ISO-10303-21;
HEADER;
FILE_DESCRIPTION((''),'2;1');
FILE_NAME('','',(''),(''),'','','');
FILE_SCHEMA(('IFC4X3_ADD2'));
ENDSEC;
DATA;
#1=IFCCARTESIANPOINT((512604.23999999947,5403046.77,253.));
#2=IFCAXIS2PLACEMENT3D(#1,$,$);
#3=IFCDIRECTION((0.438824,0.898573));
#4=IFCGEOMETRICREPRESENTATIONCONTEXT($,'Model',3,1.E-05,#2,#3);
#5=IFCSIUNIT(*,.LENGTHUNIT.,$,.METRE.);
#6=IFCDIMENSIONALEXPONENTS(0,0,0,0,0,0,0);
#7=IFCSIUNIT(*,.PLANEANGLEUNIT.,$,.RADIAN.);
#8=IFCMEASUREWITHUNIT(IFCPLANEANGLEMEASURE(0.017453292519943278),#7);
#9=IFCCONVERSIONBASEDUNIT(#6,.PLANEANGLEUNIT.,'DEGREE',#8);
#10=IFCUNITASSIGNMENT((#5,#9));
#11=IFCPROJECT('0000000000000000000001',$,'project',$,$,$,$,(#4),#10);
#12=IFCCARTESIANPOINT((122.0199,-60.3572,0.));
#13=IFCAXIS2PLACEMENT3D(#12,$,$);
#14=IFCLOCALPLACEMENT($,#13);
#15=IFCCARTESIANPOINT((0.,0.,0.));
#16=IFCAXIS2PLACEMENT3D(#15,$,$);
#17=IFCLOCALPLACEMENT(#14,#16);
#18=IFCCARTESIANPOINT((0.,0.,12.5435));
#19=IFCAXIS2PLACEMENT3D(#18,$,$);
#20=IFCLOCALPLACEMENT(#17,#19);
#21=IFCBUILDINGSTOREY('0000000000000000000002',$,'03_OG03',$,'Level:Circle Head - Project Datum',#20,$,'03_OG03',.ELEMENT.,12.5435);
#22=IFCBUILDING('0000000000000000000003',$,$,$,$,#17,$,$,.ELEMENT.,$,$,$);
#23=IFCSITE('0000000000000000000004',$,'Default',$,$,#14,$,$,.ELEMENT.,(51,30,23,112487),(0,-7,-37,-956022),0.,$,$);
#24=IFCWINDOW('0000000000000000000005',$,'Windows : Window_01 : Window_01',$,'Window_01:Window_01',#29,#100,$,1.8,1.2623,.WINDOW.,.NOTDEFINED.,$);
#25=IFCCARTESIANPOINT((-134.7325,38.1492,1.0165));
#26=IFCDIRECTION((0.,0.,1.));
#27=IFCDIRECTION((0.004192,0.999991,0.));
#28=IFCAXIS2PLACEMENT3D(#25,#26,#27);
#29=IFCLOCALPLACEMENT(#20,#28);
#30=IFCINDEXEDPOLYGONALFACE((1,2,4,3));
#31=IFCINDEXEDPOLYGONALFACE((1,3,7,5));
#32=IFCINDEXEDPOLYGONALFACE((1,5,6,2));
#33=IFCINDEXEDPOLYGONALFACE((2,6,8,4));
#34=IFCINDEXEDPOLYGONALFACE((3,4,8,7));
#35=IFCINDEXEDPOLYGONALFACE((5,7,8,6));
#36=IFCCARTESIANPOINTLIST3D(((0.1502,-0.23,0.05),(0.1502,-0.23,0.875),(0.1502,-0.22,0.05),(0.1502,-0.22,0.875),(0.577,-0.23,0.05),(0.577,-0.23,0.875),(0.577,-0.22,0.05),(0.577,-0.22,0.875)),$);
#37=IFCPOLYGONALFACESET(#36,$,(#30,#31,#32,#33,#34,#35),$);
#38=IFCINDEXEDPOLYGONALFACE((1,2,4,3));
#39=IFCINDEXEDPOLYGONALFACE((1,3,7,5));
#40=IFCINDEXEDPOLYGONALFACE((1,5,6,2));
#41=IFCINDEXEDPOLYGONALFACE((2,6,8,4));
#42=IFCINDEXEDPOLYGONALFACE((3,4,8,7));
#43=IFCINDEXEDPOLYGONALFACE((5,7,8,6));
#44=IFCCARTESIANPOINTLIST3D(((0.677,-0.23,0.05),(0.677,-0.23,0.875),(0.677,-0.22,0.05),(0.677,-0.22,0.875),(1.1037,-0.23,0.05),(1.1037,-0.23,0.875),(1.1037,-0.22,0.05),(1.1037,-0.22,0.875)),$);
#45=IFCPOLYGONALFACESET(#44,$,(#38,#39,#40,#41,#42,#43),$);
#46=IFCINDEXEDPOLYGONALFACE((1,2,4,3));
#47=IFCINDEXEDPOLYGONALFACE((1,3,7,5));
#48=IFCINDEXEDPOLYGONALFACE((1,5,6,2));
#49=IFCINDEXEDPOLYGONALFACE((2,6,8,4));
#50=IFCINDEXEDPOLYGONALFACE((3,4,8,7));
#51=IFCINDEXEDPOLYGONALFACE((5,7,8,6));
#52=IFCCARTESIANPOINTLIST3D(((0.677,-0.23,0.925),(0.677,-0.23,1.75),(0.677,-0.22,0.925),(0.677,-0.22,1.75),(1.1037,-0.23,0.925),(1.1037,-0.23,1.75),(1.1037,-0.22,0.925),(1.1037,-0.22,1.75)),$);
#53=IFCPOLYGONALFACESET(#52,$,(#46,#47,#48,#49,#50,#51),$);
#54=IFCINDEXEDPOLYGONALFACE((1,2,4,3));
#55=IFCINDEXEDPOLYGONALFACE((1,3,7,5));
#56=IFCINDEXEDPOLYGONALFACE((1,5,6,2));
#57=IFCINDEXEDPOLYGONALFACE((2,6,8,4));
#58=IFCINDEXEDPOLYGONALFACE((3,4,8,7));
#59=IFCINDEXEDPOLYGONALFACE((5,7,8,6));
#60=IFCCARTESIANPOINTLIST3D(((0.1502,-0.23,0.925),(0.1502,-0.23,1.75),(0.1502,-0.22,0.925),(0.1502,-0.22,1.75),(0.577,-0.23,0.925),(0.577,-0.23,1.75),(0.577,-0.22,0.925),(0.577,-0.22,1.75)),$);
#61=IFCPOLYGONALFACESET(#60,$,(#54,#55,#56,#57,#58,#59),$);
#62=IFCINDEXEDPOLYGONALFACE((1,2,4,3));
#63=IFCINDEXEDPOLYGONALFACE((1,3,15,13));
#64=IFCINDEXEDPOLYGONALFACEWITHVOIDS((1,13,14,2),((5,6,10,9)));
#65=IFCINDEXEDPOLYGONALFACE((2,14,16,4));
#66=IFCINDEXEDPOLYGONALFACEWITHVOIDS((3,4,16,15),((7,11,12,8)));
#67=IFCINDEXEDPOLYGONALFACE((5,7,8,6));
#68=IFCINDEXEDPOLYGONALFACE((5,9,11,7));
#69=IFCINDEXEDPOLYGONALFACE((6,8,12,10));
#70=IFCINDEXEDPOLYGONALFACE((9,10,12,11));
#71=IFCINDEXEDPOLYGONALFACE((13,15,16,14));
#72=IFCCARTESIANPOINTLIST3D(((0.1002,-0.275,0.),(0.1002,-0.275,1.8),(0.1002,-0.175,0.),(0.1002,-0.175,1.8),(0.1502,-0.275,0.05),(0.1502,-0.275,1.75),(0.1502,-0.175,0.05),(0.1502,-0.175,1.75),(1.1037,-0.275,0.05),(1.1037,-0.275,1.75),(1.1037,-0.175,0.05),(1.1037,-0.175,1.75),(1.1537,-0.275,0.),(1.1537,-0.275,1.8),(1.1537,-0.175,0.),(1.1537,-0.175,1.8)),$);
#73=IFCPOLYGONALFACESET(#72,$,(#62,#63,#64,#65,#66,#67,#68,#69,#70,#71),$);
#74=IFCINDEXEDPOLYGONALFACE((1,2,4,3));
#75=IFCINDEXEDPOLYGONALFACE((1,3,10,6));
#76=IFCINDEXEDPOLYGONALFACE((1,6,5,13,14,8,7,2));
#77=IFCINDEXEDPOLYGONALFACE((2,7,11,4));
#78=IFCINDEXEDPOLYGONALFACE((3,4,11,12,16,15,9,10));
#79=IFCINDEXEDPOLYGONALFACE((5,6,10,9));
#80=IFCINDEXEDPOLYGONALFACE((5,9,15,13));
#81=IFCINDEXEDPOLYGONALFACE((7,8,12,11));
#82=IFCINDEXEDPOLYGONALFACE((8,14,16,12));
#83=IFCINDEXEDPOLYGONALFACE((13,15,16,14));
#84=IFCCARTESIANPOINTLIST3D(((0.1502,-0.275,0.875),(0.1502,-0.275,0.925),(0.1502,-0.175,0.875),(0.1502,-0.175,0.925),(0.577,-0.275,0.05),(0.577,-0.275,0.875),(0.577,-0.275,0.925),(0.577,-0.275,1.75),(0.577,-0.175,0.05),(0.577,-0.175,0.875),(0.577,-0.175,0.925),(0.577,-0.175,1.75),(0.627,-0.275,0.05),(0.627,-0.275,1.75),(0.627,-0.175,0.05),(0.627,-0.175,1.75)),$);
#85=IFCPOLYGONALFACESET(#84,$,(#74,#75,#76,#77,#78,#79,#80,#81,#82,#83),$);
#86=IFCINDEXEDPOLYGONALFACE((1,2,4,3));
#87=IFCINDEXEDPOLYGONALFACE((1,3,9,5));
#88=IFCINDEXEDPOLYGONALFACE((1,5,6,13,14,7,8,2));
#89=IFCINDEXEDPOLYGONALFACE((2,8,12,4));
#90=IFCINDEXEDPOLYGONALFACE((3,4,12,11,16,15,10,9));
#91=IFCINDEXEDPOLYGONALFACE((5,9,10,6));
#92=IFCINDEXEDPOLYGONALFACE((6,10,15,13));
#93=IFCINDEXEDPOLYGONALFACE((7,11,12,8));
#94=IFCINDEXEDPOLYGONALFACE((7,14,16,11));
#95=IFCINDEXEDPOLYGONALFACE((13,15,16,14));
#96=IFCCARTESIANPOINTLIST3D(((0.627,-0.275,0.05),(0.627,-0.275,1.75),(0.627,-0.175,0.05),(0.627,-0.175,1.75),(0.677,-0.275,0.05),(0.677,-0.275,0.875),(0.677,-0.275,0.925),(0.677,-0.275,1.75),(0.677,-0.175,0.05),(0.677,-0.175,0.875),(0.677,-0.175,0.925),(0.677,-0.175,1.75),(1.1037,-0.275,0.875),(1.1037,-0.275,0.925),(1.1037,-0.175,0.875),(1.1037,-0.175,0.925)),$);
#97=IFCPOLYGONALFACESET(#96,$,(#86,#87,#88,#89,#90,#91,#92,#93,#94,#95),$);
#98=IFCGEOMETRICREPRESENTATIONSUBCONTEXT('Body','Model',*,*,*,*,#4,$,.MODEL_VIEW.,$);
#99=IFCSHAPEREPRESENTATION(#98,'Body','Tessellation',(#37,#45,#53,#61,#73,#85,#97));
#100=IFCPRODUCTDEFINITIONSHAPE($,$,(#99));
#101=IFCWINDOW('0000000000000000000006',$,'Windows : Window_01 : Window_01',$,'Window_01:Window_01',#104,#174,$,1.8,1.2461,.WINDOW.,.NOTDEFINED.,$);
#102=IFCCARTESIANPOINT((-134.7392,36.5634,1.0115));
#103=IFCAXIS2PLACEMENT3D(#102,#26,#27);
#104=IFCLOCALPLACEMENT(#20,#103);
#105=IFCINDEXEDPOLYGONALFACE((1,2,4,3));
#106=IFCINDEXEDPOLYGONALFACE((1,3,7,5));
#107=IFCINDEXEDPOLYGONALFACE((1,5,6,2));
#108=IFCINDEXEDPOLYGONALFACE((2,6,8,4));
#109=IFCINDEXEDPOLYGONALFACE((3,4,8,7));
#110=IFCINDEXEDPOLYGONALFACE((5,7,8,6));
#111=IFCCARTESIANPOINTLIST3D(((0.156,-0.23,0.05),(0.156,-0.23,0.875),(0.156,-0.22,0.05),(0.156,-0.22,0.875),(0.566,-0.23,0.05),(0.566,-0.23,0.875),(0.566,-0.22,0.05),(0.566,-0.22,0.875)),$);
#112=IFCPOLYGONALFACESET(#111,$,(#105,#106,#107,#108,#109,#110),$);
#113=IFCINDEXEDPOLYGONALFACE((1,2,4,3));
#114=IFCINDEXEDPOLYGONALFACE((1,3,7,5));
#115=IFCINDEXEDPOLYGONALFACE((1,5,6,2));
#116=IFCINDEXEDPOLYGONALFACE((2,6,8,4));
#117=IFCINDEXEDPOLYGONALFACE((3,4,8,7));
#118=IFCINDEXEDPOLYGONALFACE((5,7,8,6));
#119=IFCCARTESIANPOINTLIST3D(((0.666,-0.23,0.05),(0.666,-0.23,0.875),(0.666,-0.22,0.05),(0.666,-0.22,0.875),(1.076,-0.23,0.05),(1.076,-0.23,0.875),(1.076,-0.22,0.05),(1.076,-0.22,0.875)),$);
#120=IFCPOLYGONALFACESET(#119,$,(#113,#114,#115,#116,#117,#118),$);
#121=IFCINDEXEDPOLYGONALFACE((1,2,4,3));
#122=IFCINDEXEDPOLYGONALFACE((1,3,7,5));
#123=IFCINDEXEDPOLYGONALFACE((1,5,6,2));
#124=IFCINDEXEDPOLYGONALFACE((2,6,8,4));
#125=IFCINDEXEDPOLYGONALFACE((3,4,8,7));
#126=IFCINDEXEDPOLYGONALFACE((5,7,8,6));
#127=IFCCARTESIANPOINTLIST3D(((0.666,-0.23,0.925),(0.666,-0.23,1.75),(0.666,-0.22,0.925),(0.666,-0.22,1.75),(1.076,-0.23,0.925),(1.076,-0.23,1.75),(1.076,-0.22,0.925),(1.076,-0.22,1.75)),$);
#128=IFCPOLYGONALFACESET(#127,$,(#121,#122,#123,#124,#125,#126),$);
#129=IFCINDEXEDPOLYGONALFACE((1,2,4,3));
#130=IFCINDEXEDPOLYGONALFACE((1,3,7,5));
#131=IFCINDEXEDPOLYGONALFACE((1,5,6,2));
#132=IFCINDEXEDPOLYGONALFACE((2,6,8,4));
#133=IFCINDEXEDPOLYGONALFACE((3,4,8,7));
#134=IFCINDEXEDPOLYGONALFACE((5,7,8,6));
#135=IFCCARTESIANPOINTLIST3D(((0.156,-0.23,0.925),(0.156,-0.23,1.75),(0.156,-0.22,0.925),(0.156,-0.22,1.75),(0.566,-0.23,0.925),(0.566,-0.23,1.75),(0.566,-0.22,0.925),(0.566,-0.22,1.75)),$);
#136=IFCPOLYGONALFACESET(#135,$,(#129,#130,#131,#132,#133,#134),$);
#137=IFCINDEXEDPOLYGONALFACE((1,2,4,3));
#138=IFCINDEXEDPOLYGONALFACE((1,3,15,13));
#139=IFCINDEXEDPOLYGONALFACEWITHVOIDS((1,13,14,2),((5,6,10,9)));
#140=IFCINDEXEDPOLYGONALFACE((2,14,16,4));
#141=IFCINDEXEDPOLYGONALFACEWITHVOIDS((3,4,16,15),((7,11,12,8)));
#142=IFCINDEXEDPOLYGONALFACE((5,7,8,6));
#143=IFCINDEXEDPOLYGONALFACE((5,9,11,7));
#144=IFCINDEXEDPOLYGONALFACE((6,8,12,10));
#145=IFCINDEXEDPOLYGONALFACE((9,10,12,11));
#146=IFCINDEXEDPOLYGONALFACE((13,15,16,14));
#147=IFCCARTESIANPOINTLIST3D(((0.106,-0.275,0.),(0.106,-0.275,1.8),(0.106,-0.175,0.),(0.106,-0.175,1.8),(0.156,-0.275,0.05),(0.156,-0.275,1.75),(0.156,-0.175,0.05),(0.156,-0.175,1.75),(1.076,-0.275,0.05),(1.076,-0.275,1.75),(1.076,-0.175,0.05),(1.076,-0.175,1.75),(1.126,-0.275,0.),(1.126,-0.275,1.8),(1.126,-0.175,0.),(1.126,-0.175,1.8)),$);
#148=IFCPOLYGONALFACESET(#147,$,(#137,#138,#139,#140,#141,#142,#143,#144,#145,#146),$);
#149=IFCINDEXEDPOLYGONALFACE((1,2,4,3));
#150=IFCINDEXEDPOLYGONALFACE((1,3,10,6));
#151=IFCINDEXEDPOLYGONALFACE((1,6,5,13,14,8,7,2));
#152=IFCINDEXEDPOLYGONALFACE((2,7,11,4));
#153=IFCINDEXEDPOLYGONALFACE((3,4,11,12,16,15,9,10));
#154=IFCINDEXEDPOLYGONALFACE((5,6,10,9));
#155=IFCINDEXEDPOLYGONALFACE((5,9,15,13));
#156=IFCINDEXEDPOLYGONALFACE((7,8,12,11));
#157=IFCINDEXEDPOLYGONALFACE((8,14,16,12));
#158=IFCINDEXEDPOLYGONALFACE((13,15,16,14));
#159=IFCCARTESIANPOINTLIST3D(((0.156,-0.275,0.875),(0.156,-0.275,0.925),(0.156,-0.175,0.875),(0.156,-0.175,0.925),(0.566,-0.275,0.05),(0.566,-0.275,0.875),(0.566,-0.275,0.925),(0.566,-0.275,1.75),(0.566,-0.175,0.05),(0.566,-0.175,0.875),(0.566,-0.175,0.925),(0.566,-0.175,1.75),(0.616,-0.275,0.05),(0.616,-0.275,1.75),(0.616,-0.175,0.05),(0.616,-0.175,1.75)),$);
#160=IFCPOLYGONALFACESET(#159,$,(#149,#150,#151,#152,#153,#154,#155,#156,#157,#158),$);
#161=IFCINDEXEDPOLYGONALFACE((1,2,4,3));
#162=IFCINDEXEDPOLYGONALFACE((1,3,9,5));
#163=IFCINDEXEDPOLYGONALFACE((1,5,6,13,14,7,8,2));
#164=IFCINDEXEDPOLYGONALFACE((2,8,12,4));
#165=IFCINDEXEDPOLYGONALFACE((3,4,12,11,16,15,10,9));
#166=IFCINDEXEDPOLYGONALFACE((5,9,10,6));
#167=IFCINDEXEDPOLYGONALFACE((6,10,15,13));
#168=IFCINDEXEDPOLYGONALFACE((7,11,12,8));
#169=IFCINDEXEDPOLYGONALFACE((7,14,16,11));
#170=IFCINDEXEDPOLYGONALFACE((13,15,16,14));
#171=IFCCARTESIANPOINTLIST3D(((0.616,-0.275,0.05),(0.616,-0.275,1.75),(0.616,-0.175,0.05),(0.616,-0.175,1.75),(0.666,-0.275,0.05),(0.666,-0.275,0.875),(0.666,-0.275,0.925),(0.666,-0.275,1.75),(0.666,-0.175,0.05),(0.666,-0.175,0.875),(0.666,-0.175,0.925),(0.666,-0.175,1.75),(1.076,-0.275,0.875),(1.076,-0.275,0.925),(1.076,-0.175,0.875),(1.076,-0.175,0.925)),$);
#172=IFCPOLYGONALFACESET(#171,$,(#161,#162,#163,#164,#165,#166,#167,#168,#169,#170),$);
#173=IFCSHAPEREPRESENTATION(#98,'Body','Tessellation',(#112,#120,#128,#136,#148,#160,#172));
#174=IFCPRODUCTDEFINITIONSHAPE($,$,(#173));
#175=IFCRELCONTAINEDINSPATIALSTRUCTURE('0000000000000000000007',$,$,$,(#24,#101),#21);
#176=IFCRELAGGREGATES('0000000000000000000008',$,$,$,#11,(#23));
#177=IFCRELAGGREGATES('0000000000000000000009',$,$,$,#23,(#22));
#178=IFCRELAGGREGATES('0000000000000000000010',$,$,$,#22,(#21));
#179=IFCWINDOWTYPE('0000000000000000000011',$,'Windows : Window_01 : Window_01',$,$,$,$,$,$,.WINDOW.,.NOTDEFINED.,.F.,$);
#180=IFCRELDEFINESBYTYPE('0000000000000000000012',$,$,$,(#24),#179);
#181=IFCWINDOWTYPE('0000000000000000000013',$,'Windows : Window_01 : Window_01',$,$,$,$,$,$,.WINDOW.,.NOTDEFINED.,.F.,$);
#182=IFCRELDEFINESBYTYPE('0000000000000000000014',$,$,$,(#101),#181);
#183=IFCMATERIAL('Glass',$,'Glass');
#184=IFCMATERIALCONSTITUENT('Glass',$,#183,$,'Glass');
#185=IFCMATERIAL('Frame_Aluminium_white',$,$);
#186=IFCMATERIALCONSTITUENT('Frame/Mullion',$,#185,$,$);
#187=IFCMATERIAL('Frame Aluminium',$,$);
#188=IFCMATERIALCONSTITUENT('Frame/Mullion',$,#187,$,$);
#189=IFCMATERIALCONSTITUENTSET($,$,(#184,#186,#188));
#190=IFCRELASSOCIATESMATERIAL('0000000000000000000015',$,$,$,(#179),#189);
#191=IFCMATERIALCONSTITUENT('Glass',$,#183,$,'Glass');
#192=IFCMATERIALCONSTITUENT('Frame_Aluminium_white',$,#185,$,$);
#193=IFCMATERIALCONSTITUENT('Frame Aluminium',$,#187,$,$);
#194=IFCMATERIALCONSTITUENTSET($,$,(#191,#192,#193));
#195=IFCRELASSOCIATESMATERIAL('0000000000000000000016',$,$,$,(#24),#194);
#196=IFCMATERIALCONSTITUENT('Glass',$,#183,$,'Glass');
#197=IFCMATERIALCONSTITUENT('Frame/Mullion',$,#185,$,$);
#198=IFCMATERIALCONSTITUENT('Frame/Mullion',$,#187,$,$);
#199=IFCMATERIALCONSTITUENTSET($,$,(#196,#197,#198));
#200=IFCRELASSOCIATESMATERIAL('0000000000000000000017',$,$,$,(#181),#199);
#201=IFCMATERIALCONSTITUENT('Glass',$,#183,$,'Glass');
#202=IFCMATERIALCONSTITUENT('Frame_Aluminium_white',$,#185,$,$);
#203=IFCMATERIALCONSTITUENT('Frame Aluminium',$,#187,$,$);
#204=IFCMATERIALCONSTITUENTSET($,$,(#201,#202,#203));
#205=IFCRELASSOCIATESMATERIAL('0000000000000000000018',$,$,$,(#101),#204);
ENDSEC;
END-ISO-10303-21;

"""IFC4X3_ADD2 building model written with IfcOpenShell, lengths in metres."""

from ifc_helpers import new_model, entity, si_unit, converted_unit, direction, frame, frame_2d, origin, place, context, subcontext, project, spatial, polyline, rectangle, outline, extrude, source, transform, mapped, material, constituent, constituent_set, type_object, type_shapes, element, save


model = new_model("IFC4X3_ADD2")

# Units and contexts
model_context = context("Model", 3, precision=1e-05, world=frame((512604.23999999947, 5403046.77, 253.0)), true_north=direction((0.438824, 0.898573)))
body_context = subcontext(model_context, "Body", "Model", "MODEL_VIEW")
ifc_project = project(units=[si_unit("LENGTHUNIT", "METRE"), converted_unit("PLANEANGLEUNIT", "DEGREE", entity("IfcPlaneAngleMeasure", 0.017453292519943278), si_unit("PLANEANGLEUNIT", "RADIAN"), dimensions=[0, 0, 0, 0, 0, 0, 0])], contexts=[model_context])

# Site, building, storey
site_placement = place(None, frame((122.0199, -60.3572, 0.0)))
site = spatial("IfcSite", under=ifc_project, at=site_placement, Name="Default", CompositionType="ELEMENT", RefLatitude=(51, 30, 23, 112487), RefLongitude=(0, -7, -37, -956022), RefElevation=0.0)
building_placement = place(site_placement, origin())
building = spatial("IfcBuilding", under=site, at=building_placement, CompositionType="ELEMENT")
storey_placement = place(building_placement, frame((0.0, 0.0, 12.5435)))
storey = spatial("IfcBuildingStorey", under=building, at=storey_placement, Name="03_OG03", ObjectType="Level:Circle Head - Project Datum", LongName="03_OG03", CompositionType="ELEMENT", Elevation=12.5435)

# Windows
ifc_material_1 = material(Name="Glass", Category="Glass")
ifc_material_2 = material(Name="Frame_Aluminium_white")
ifc_material_3 = material(Name="Frame Aluminium")
ifc_constituent_1 = constituent(ifc_material_1, Name="Glass", Category="Glass")
ifc_constituent_2 = constituent(ifc_material_2, Name="Frame_Aluminium_white")
ifc_constituent_3 = constituent(ifc_material_3, Name="Frame Aluminium")
ifc_constituent_set_1 = constituent_set(constituents=[ifc_constituent_1, ifc_constituent_2, ifc_constituent_3])
ifc_constituent_4 = constituent(ifc_material_1, Name="Glass", Category="Glass")
ifc_constituent_5 = constituent(ifc_material_2, Name="Frame/Mullion")
ifc_constituent_6 = constituent(ifc_material_3, Name="Frame/Mullion")
ifc_constituent_set_2 = constituent_set(constituents=[ifc_constituent_4, ifc_constituent_5, ifc_constituent_6])
window_type_1 = type_object("IfcWindowType", Name="Windows : Window_01 : Window_01", ParameterTakesPrecedence=False, PartitioningType="NOTDEFINED", PredefinedType="WINDOW", material=ifc_constituent_set_2)
shared_shape_1 = source(origin(), body_context, "Body", "SweptSolid", [
    extrude(rectangle(XDim=0.4267, YDim=0.01, at=frame_2d((0.0, 0.0), x_axis=(1.0, 0.0))), frame((0.3636, -0.225, 0.05), z_axis=(0.0, 0.0, 1.0), x_axis=(-1.0, 0.0, 0.0)), (0.0, 0.0, 1.0), 0.825),
    extrude(rectangle(XDim=0.4267, YDim=0.01, at=frame_2d((0.0, 0.0), x_axis=(1.0, 0.0))), frame((0.8903, -0.225, 0.05), z_axis=(0.0, 0.0, 1.0), x_axis=(-1.0, 0.0, 0.0)), (0.0, 0.0, 1.0), 0.825),
    extrude(rectangle(XDim=0.4267, YDim=0.01, at=frame_2d((0.0, 0.0), x_axis=(1.0, 0.0))), frame((0.8903, -0.225, 0.925), z_axis=(0.0, 0.0, 1.0), x_axis=(-1.0, 0.0, 0.0)), (0.0, 0.0, 1.0), 0.825),
    extrude(rectangle(XDim=0.4267, YDim=0.01, at=frame_2d((0.0, 0.0), x_axis=(1.0, 0.0))), frame((0.3636, -0.225, 0.925), z_axis=(0.0, 0.0, 1.0), x_axis=(-1.0, 0.0, 0.0)), (0.0, 0.0, 1.0), 0.825),
    extrude(outline(polyline([(-0.9, -0.5267), (0.9, -0.5267), (0.9, 0.5267), (-0.9, 0.5267), (-0.9, -0.5267)]), holes=[polyline([(0.85, 0.4767), (0.85, -0.4767), (-0.85, -0.4767), (-0.85, 0.4767), (0.85, 0.4767)])]), frame((0.627, -0.275, 0.9), z_axis=(0.0, 1.0, 0.0), x_axis=(0.0, 0.0, 1.0)), (0.0, 0.0, 1.0), 0.1),
    extrude(outline(polyline([(0.025, 0.0942), (0.85, 0.0942), (0.85, 0.1442), (-0.85, 0.1442), (-0.85, 0.0942), (-0.025, 0.0942), (-0.025, -0.3325), (0.025, -0.3325), (0.025, 0.0942)])), frame((0.4828, -0.275, 0.9), z_axis=(0.0, 1.0, 0.0), x_axis=(0.0, 0.0, 1.0)), (0.0, 0.0, 1.0), 0.1),
    extrude(outline(polyline([(-0.85, -0.0942), (-0.85, -0.1442), (0.85, -0.1442), (0.85, -0.0942), (0.025, -0.0942), (0.025, 0.3325), (-0.025, 0.3325), (-0.025, -0.0942), (-0.85, -0.0942)])), frame((0.7711, -0.275, 0.9), z_axis=(0.0, -1.0, 0.0), x_axis=(0.0, 0.0, -1.0)), (0.0, 0.0, -1.0), 0.1),
])
type_shapes(window_type_1, [shared_shape_1])
window_1_placement = place(storey_placement, frame((-134.7325, 38.1492, 1.0165), z_axis=(0.0, 0.0, 1.0), x_axis=(0.004192, 0.999991, 0.0)))
element("IfcWindow", 1, at=window_1_placement, inside=storey, type_object=window_type_1, material=ifc_constituent_set_1, Name="Windows : Window_01 : Window_01", ObjectType="Window_01:Window_01", OverallHeight=1.8, OverallWidth=1.2623, PartitioningType="NOTDEFINED", PredefinedType="WINDOW", context=body_context, shape_type="MappedRepresentation", body=[
    mapped(shared_shape_1, transform((0.0, 0.0, 0.0), scale=1.0)),
])
ifc_constituent_7 = constituent(ifc_material_1, Name="Glass", Category="Glass")
ifc_constituent_8 = constituent(ifc_material_2, Name="Frame_Aluminium_white")
ifc_constituent_9 = constituent(ifc_material_3, Name="Frame Aluminium")
ifc_constituent_set_3 = constituent_set(constituents=[ifc_constituent_7, ifc_constituent_8, ifc_constituent_9])
ifc_constituent_10 = constituent(ifc_material_1, Name="Glass", Category="Glass")
ifc_constituent_11 = constituent(ifc_material_2, Name="Frame/Mullion")
ifc_constituent_12 = constituent(ifc_material_3, Name="Frame/Mullion")
ifc_constituent_set_4 = constituent_set(constituents=[ifc_constituent_10, ifc_constituent_11, ifc_constituent_12])
window_type_2 = type_object("IfcWindowType", Name="Windows : Window_01 : Window_01", ParameterTakesPrecedence=False, PartitioningType="NOTDEFINED", PredefinedType="WINDOW", material=ifc_constituent_set_4)
shared_shape_2 = source(origin(), body_context, "Body", "SweptSolid", [
    extrude(rectangle(XDim=0.41, YDim=0.01, at=frame_2d((0.0, 0.0), x_axis=(1.0, 0.0))), frame((0.361, -0.225, 0.05), z_axis=(0.0, 0.0, 1.0), x_axis=(-1.0, 0.0, 0.0)), (0.0, 0.0, 1.0), 0.825),
    extrude(rectangle(XDim=0.41, YDim=0.01, at=frame_2d((0.0, 0.0), x_axis=(1.0, 0.0))), frame((0.871, -0.225, 0.05), z_axis=(0.0, 0.0, 1.0), x_axis=(-1.0, 0.0, 0.0)), (0.0, 0.0, 1.0), 0.825),
    extrude(rectangle(XDim=0.41, YDim=0.01, at=frame_2d((0.0, 0.0), x_axis=(1.0, 0.0))), frame((0.871, -0.225, 0.925), z_axis=(0.0, 0.0, 1.0), x_axis=(-1.0, 0.0, 0.0)), (0.0, 0.0, 1.0), 0.825),
    extrude(rectangle(XDim=0.41, YDim=0.01, at=frame_2d((0.0, 0.0), x_axis=(1.0, 0.0))), frame((0.361, -0.225, 0.925), z_axis=(0.0, 0.0, 1.0), x_axis=(-1.0, 0.0, 0.0)), (0.0, 0.0, 1.0), 0.825),
    extrude(outline(polyline([(-0.9, -0.51), (0.9, -0.51), (0.9, 0.51), (-0.9, 0.51), (-0.9, -0.51)]), holes=[polyline([(0.85, 0.46), (0.85, -0.46), (-0.85, -0.46), (-0.85, 0.46), (0.85, 0.46)])]), frame((0.616, -0.275, 0.9), z_axis=(0.0, 1.0, 0.0), x_axis=(0.0, 0.0, 1.0)), (0.0, 0.0, 1.0), 0.1),
    extrude(outline(polyline([(0.025, 0.09), (0.85, 0.09), (0.85, 0.14), (-0.85, 0.14), (-0.85, 0.09), (-0.025, 0.09), (-0.025, -0.32), (0.025, -0.32), (0.025, 0.09)])), frame((0.476, -0.275, 0.9), z_axis=(0.0, 1.0, 0.0), x_axis=(0.0, 0.0, 1.0)), (0.0, 0.0, 1.0), 0.1),
    extrude(outline(polyline([(-0.85, -0.09), (-0.85, -0.14), (0.85, -0.14), (0.85, -0.09), (0.025, -0.09), (0.025, 0.32), (-0.025, 0.32), (-0.025, -0.09), (-0.85, -0.09)])), frame((0.756, -0.275, 0.9), z_axis=(0.0, -1.0, 0.0), x_axis=(0.0, 0.0, -1.0)), (0.0, 0.0, -1.0), 0.1),
])
type_shapes(window_type_2, [shared_shape_2])
window_2_placement = place(storey_placement, frame((-134.7392, 36.5634, 1.0115), z_axis=(0.0, 0.0, 1.0), x_axis=(0.004192, 0.999991, 0.0)))
element("IfcWindow", 2, at=window_2_placement, inside=storey, type_object=window_type_2, material=ifc_constituent_set_3, Name="Windows : Window_01 : Window_01", ObjectType="Window_01:Window_01", OverallHeight=1.8, OverallWidth=1.2461, PartitioningType="NOTDEFINED", PredefinedType="WINDOW", context=body_context, shape_type="MappedRepresentation", body=[
    mapped(shared_shape_2, transform((0.0, 0.0, 0.0), scale=1.0)),
])

save(model, "model.ifc")
